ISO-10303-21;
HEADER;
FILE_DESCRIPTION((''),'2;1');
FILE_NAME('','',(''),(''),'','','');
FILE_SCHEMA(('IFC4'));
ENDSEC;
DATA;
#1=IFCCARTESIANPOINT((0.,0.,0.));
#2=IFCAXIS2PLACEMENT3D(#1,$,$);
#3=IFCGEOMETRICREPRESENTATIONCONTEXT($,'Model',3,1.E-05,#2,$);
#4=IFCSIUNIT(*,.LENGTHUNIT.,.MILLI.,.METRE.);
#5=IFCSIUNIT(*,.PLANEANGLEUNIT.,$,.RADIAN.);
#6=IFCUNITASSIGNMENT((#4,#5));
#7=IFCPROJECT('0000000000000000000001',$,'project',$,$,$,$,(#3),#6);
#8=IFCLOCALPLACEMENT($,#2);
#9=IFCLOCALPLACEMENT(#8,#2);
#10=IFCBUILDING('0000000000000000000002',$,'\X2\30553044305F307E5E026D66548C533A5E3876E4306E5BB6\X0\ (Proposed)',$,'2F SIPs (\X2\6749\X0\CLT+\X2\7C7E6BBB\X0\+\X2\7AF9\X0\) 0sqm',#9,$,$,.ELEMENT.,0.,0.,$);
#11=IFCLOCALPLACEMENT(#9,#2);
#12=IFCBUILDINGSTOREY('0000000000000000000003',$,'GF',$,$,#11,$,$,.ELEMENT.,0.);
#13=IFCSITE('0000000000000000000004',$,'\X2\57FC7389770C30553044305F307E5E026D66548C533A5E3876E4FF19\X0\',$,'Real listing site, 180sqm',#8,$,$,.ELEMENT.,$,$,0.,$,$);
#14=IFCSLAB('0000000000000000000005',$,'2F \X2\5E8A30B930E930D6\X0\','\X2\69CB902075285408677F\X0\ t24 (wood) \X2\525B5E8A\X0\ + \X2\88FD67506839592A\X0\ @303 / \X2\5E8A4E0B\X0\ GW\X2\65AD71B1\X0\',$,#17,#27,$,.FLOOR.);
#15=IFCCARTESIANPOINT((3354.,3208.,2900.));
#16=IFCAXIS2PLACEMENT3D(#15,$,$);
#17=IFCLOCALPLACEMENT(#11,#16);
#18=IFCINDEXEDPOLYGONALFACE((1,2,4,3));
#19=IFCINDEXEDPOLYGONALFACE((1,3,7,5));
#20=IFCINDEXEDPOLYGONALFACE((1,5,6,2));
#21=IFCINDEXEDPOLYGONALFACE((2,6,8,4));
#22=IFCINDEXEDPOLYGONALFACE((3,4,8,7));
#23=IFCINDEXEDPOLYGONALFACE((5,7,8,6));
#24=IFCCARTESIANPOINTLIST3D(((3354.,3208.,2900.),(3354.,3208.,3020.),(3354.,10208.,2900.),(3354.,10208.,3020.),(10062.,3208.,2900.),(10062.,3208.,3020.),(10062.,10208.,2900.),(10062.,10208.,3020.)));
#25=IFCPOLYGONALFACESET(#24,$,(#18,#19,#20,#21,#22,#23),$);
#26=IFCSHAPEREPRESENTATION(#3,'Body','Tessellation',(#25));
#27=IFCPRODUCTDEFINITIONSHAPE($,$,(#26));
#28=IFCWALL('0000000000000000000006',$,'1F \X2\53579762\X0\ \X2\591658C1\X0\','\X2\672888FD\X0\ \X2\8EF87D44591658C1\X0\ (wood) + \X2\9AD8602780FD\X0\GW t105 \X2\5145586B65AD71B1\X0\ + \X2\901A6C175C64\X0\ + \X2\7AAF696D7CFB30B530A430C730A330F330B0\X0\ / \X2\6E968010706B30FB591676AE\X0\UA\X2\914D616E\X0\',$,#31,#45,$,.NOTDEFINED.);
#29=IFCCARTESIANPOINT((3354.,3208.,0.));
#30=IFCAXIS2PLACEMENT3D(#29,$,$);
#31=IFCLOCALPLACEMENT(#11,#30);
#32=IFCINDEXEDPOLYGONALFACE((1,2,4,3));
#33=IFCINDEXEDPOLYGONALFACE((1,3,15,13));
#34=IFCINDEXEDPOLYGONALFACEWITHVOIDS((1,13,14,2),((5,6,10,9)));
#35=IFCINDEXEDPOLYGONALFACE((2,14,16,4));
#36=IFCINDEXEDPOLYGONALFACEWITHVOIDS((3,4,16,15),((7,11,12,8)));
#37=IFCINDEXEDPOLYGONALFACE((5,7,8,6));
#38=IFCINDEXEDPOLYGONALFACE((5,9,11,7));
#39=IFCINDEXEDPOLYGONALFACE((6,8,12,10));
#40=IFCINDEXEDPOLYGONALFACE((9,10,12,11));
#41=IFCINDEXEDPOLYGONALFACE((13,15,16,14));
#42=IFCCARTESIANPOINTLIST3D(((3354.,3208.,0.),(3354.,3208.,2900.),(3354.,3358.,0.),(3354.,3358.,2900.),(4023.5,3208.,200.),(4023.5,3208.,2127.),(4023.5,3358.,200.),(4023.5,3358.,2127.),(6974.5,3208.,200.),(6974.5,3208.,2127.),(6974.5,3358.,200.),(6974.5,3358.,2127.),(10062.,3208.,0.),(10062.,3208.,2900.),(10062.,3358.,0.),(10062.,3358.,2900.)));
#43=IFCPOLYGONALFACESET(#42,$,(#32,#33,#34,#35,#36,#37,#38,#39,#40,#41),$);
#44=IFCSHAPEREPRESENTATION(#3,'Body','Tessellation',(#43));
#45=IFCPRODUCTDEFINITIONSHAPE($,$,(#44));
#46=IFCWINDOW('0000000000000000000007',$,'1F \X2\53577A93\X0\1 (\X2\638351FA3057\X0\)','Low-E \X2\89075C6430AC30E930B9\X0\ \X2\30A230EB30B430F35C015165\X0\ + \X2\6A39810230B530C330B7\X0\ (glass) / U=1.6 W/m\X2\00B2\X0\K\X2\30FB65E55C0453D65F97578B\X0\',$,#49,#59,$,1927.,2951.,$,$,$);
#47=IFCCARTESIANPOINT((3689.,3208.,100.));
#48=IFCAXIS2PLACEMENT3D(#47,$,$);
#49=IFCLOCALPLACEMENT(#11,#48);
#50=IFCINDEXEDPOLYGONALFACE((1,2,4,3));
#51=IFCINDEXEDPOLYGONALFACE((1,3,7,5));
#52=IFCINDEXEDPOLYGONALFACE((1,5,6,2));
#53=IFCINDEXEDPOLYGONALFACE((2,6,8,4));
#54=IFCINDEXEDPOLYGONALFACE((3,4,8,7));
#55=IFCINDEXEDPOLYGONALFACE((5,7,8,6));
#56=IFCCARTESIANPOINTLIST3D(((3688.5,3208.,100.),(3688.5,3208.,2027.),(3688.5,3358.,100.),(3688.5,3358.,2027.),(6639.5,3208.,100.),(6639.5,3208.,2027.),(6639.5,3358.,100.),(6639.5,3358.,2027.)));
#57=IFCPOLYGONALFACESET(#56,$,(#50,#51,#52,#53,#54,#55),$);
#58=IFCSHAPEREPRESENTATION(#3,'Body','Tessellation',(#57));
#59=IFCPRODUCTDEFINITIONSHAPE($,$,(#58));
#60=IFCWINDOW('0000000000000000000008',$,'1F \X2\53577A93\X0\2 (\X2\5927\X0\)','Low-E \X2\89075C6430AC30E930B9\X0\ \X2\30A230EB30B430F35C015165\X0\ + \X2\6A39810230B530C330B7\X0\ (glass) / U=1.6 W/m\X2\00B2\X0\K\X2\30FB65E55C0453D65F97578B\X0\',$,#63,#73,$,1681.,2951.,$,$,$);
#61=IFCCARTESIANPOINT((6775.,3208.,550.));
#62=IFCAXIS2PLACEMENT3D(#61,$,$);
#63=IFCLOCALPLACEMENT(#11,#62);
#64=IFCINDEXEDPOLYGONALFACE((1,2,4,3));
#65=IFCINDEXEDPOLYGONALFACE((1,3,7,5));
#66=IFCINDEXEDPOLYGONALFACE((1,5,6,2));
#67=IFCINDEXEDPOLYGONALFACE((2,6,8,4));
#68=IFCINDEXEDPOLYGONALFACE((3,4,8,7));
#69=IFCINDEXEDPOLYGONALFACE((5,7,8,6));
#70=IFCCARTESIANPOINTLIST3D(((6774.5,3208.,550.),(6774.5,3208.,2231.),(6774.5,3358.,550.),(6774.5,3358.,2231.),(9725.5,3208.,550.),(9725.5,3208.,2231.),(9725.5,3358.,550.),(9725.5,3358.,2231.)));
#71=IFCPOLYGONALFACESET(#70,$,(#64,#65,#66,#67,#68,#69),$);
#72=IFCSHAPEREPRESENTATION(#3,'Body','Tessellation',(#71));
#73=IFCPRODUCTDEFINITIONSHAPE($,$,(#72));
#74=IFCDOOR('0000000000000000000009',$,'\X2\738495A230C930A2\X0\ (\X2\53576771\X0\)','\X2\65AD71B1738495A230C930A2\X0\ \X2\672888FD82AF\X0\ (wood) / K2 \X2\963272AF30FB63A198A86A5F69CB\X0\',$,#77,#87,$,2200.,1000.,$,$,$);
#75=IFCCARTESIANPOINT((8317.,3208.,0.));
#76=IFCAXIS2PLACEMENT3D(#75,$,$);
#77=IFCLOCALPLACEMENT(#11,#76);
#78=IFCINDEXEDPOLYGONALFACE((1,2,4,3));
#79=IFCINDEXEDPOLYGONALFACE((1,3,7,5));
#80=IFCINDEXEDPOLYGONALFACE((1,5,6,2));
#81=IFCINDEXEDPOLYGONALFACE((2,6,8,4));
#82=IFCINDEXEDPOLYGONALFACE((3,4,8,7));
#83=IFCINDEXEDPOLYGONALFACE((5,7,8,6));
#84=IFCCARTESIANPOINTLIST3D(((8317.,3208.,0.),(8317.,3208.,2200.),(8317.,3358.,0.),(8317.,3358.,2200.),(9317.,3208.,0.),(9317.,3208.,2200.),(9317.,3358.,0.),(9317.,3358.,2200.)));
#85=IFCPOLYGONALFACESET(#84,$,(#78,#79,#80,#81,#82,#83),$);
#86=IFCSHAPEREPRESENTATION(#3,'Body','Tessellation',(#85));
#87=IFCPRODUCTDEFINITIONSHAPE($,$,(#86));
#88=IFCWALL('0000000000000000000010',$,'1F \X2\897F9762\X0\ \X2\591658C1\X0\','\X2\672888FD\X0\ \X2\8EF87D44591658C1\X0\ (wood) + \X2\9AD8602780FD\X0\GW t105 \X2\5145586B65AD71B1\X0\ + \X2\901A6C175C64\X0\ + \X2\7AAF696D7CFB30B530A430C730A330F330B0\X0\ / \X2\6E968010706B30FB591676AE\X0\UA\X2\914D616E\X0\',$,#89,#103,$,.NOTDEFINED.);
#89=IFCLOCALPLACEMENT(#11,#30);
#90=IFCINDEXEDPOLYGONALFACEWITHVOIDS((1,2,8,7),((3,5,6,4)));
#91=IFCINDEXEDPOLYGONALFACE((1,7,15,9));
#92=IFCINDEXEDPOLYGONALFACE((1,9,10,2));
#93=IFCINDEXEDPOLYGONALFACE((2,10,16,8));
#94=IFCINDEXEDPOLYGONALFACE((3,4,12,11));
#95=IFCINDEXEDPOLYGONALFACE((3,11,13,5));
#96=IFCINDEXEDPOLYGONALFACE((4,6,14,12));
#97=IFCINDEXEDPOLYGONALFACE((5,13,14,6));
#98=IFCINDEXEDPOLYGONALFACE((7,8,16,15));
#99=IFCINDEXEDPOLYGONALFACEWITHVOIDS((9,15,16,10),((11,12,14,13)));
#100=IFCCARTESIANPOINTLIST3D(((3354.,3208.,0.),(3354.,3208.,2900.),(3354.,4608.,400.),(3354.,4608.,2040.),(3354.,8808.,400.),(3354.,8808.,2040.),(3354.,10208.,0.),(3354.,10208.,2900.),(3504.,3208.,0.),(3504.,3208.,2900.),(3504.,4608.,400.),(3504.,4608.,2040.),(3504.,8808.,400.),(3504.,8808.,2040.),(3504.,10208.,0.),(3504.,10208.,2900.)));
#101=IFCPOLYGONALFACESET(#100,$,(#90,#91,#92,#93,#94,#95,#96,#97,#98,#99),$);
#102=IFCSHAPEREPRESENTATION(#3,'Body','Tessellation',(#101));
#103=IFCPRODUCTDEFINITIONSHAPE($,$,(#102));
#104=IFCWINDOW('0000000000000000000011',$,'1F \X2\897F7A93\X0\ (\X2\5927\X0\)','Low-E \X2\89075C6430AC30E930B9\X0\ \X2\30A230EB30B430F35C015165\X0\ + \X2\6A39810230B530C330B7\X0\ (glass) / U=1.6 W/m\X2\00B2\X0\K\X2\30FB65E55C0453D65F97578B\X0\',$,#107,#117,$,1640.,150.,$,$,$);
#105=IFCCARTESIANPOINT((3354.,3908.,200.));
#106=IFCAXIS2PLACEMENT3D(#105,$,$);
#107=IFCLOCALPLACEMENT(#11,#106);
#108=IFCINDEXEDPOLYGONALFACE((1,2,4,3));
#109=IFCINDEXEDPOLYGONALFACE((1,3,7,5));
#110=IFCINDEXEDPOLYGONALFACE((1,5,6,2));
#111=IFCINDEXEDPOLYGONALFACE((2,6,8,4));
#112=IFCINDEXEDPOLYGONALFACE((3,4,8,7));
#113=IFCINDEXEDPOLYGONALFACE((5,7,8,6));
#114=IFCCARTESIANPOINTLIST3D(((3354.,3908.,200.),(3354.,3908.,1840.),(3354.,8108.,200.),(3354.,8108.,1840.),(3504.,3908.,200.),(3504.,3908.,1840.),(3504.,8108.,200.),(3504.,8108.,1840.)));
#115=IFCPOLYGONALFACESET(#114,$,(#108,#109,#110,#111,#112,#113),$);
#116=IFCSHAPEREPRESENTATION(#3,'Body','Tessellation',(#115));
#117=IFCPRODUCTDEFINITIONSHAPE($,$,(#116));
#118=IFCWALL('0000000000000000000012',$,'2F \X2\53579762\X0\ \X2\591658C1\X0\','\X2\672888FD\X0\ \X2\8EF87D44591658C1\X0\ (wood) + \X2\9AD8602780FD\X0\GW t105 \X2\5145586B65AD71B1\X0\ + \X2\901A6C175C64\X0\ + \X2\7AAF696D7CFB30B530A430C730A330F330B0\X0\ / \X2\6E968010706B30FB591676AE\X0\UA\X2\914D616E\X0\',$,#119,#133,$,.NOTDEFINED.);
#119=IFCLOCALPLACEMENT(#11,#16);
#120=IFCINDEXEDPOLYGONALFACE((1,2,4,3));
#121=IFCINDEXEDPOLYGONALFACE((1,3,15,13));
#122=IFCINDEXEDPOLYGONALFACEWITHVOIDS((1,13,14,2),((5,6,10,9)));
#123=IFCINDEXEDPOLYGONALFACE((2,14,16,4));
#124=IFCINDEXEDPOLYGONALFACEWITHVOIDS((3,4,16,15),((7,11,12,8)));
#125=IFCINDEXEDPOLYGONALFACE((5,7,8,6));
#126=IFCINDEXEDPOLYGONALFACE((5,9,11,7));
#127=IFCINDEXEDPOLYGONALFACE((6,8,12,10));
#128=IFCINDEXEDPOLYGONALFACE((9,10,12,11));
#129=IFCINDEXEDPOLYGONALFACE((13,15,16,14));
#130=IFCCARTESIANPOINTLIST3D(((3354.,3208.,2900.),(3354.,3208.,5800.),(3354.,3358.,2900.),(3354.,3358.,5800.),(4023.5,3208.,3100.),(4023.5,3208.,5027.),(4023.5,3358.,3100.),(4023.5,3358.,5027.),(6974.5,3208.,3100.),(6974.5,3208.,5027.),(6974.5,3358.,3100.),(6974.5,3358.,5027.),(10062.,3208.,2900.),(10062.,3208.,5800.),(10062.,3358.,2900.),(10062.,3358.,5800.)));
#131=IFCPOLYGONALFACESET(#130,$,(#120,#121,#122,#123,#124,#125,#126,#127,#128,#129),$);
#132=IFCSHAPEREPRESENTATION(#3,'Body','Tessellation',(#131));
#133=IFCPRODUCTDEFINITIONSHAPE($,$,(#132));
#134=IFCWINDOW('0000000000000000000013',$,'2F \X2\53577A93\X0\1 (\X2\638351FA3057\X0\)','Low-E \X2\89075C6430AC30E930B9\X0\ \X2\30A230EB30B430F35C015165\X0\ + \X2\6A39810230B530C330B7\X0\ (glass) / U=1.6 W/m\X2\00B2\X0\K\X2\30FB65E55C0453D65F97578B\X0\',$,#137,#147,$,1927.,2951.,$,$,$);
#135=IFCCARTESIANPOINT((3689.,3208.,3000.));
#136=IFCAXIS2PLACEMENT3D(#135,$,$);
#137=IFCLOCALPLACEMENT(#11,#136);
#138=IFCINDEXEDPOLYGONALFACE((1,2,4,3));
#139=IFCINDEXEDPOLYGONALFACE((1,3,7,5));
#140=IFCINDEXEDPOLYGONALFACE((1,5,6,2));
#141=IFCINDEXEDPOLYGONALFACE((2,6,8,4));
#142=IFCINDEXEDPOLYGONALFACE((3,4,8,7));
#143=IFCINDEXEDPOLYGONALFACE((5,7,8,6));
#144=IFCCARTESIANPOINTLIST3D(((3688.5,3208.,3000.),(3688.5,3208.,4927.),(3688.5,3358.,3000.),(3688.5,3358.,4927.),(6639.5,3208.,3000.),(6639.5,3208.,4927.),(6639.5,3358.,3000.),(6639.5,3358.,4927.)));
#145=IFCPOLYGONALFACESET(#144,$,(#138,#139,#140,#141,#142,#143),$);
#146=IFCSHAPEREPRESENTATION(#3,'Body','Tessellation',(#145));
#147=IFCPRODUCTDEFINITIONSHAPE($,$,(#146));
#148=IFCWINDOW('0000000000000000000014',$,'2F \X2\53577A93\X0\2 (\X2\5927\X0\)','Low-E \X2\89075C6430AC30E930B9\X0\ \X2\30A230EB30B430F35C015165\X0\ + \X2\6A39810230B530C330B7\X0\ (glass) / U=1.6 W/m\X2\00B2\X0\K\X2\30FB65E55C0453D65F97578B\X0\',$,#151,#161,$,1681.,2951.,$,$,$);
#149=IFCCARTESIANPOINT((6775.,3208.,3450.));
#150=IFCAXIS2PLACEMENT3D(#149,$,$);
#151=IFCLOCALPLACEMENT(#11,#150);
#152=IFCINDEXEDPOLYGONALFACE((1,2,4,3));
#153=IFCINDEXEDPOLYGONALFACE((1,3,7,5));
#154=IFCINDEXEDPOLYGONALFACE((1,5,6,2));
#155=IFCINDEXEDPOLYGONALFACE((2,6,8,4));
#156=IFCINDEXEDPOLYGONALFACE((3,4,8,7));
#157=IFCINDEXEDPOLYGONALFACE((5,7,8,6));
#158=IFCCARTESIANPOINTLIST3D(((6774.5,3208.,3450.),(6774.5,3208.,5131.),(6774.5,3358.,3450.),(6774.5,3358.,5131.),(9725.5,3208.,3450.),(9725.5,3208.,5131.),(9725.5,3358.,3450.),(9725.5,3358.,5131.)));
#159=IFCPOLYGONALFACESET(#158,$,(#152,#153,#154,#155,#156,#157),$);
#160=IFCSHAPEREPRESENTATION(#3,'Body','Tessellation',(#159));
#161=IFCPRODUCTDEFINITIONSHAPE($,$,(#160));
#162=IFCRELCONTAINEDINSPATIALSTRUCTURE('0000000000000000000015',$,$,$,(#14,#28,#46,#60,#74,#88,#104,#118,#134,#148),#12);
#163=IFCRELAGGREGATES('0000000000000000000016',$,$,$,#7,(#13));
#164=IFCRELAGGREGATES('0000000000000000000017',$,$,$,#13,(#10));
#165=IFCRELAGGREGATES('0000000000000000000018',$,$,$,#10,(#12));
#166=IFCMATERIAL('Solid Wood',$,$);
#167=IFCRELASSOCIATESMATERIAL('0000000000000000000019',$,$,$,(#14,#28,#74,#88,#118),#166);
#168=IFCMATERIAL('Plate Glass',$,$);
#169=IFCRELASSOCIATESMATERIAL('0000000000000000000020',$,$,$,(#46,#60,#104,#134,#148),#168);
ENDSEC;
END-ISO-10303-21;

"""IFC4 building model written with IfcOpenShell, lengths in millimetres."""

from ifc_helpers import new_model, si_unit, frame, frame_2d, origin, place, context, project, spatial, rectangle, extrude, material, element, fill, save


model = new_model("IFC4")

# Units and contexts
model_context = context("Model", 3, precision=1e-05, world=origin())
ifc_project = project(units=[si_unit("LENGTHUNIT", "METRE", prefix="MILLI"), si_unit("PLANEANGLEUNIT", "RADIAN")], contexts=[model_context])

# Site, building, storey
site_placement = place(None, origin())
site = spatial("IfcSite", under=ifc_project, at=site_placement, Name="埼玉県さいたま市浦和区常盤９", ObjectType="Real listing site, 180sqm", CompositionType="ELEMENT", RefElevation=0.0)
building_placement = place(site_placement, origin())
building = spatial("IfcBuilding", under=site, at=building_placement, Name="さいたま市浦和区常盤の家 (Proposed)", ObjectType="2F SIPs (杉CLT+籾殻+竹) 0sqm", CompositionType="ELEMENT", ElevationOfRefHeight=0.0, ElevationOfTerrain=0.0)
storey_placement = place(building_placement, origin())
storey = spatial("IfcBuildingStorey", under=building, at=storey_placement, Name="GF", CompositionType="ELEMENT", Elevation=0.0)

# Slab
ifc_material_1 = material(Name="Solid Wood")
slab_1_placement = place(storey_placement, frame((3354.0, 3208.0, 2900.0)))
element("IfcSlab", 1, at=slab_1_placement, inside=storey, material=ifc_material_1, Name="2F 床スラブ", Description="構造用合板 t24 (wood) 剛床 + 製材根太 @303 / 床下 GW断熱", PredefinedType="FLOOR", context=model_context, shape_type="SweptSolid", body=[
    extrude(rectangle(XDim=6708.0, YDim=7000.0, at=frame_2d((3354.0, 3500.0))), frame((3354.0, 3208.0, 2900.0)), (0.0, 0.0, 1.0), 120.0),
])

# Wall, openings, windows, door
wall_1_placement = place(storey_placement, frame((3354.0, 3208.0, 0.0)))
wall_1 = element("IfcWall", 2, at=wall_1_placement, inside=storey, material=ifc_material_1, Name="1F 南面 外壁", Description="木製 軸組外壁 (wood) + 高性能GW t105 充填断熱 + 通気層 + 窯業系サイディング / 準耐火・外皮UA配慮", PredefinedType="NOTDEFINED", context=model_context, shape_type="SweptSolid", body=[
    extrude(rectangle(XDim=6708.0, YDim=150.0, at=frame_2d((3354.0, 75.0))), frame((3354.0, 3208.0, 0.0)), (0.0, 0.0, 1.0), 2900.0),
])
opening_1_placement = place(storey_placement, frame((3689.0, 3208.0, 100.0)))
opening_1 = element("IfcOpeningElement", 3, at=opening_1_placement, cuts=wall_1, PredefinedType="NOTDEFINED", context=model_context, shape_type="SweptSolid", body=[
    extrude(rectangle(XDim=2951.0, YDim=150.0, at=frame_2d((1475.0, 75.0))), frame((3689.0, 3208.0, 100.0)), (0.0, 0.0, 1.0), 1927.0),
])
opening_2_placement = place(storey_placement, frame((6775.0, 3208.0, 550.0)))
opening_2 = element("IfcOpeningElement", 4, at=opening_2_placement, cuts=wall_1, PredefinedType="NOTDEFINED", context=model_context, shape_type="SweptSolid", body=[
    extrude(rectangle(XDim=2951.0, YDim=150.0, at=frame_2d((1475.0, 75.0))), frame((6775.0, 3208.0, 550.0)), (0.0, 0.0, 1.0), 1681.0),
])
opening_3_placement = place(storey_placement, frame((8317.0, 3208.0, 0.0)))
opening_3 = element("IfcOpeningElement", 5, at=opening_3_placement, cuts=wall_1, PredefinedType="NOTDEFINED", context=model_context, shape_type="SweptSolid", body=[
    extrude(rectangle(XDim=1000.0, YDim=150.0, at=frame_2d((500.0, 75.0))), frame((8317.0, 3208.0, 0.0)), (0.0, 0.0, 1.0), 2200.0),
])
ifc_material_2 = material(Name="Plate Glass")
window_1_placement = place(storey_placement, frame((3689.0, 3208.0, 100.0)))
window_1 = element("IfcWindow", 6, at=window_1_placement, inside=storey, material=ifc_material_2, Name="1F 南窓1 (掃出し)", Description="Low-E 複層ガラス アルゴン封入 + 樹脂サッシ (glass) / U=1.6 W/m²K・日射取得型", OverallHeight=1927.0, OverallWidth=2951.0, context=model_context, shape_type="SweptSolid", body=[
    extrude(rectangle(XDim=2951.0, YDim=150.0, at=frame_2d((1475.0, 75.0))), frame((3689.0, 3208.0, 100.0)), (0.0, 0.0, 1.0), 1927.0),
])
fill(opening_1, window_1)
window_2_placement = place(storey_placement, frame((6775.0, 3208.0, 550.0)))
window_2 = element("IfcWindow", 7, at=window_2_placement, inside=storey, material=ifc_material_2, Name="1F 南窓2 (大)", Description="Low-E 複層ガラス アルゴン封入 + 樹脂サッシ (glass) / U=1.6 W/m²K・日射取得型", OverallHeight=1681.0, OverallWidth=2951.0, context=model_context, shape_type="SweptSolid", body=[
    extrude(rectangle(XDim=2951.0, YDim=150.0, at=frame_2d((1475.0, 75.0))), frame((6775.0, 3208.0, 550.0)), (0.0, 0.0, 1.0), 1681.0),
])
fill(opening_2, window_2)
door_placement = place(storey_placement, frame((8317.0, 3208.0, 0.0)))
door = element("IfcDoor", 8, at=door_placement, inside=storey, material=ifc_material_1, Name="玄関ドア (南東)", Description="断熱玄関ドア 木製芯 (wood) / K2 防犯・採風機構", OverallHeight=2200.0, OverallWidth=1000.0, context=model_context, shape_type="SweptSolid", body=[
    extrude(rectangle(XDim=1000.0, YDim=150.0, at=frame_2d((500.0, 75.0))), frame((8317.0, 3208.0, 0.0)), (0.0, 0.0, 1.0), 2200.0),
])
fill(opening_3, door)

# Wall, opening, window
wall_2_placement = place(storey_placement, frame((3354.0, 3208.0, 0.0)))
wall_2 = element("IfcWall", 9, at=wall_2_placement, inside=storey, material=ifc_material_1, Name="1F 西面 外壁", Description="木製 軸組外壁 (wood) + 高性能GW t105 充填断熱 + 通気層 + 窯業系サイディング / 準耐火・外皮UA配慮", PredefinedType="NOTDEFINED", context=model_context, shape_type="SweptSolid", body=[
    extrude(rectangle(XDim=150.0, YDim=7000.0, at=frame_2d((75.0, 3500.0))), frame((3354.0, 3208.0, 0.0)), (0.0, 0.0, 1.0), 2900.0),
])
opening_4_placement = place(storey_placement, frame((3354.0, 3908.0, 200.0)))
opening_4 = element("IfcOpeningElement", 10, at=opening_4_placement, cuts=wall_2, PredefinedType="NOTDEFINED", context=model_context, shape_type="SweptSolid", body=[
    extrude(rectangle(XDim=150.0, YDim=4200.0, at=frame_2d((75.0, 2100.0))), frame((3354.0, 3908.0, 200.0)), (0.0, 0.0, 1.0), 1640.0),
])
window_3_placement = place(storey_placement, frame((3354.0, 3908.0, 200.0)))
window_3 = element("IfcWindow", 11, at=window_3_placement, inside=storey, material=ifc_material_2, Name="1F 西窓 (大)", Description="Low-E 複層ガラス アルゴン封入 + 樹脂サッシ (glass) / U=1.6 W/m²K・日射取得型", OverallHeight=1640.0, OverallWidth=150.0, context=model_context, shape_type="SweptSolid", body=[
    extrude(rectangle(XDim=150.0, YDim=4200.0, at=frame_2d((75.0, 2100.0))), frame((3354.0, 3908.0, 200.0)), (0.0, 0.0, 1.0), 1640.0),
])
fill(opening_4, window_3)

# Wall, openings, windows
wall_3_placement = place(storey_placement, frame((3354.0, 3208.0, 2900.0)))
wall_3 = element("IfcWall", 12, at=wall_3_placement, inside=storey, material=ifc_material_1, Name="2F 南面 外壁", Description="木製 軸組外壁 (wood) + 高性能GW t105 充填断熱 + 通気層 + 窯業系サイディング / 準耐火・外皮UA配慮", PredefinedType="NOTDEFINED", context=model_context, shape_type="SweptSolid", body=[
    extrude(rectangle(XDim=6708.0, YDim=150.0, at=frame_2d((3354.0, 75.0))), frame((3354.0, 3208.0, 2900.0)), (0.0, 0.0, 1.0), 2900.0),
])
opening_5_placement = place(storey_placement, frame((3689.0, 3208.0, 3000.0)))
opening_5 = element("IfcOpeningElement", 13, at=opening_5_placement, cuts=wall_3, PredefinedType="NOTDEFINED", context=model_context, shape_type="SweptSolid", body=[
    extrude(rectangle(XDim=2951.0, YDim=150.0, at=frame_2d((1475.0, 75.0))), frame((3689.0, 3208.0, 3000.0)), (0.0, 0.0, 1.0), 1927.0),
])
opening_6_placement = place(storey_placement, frame((6775.0, 3208.0, 3450.0)))
opening_6 = element("IfcOpeningElement", 14, at=opening_6_placement, cuts=wall_3, PredefinedType="NOTDEFINED", context=model_context, shape_type="SweptSolid", body=[
    extrude(rectangle(XDim=2951.0, YDim=150.0, at=frame_2d((1475.0, 75.0))), frame((6775.0, 3208.0, 3450.0)), (0.0, 0.0, 1.0), 1681.0),
])
window_4_placement = place(storey_placement, frame((3689.0, 3208.0, 3000.0)))
window_4 = element("IfcWindow", 15, at=window_4_placement, inside=storey, material=ifc_material_2, Name="2F 南窓1 (掃出し)", Description="Low-E 複層ガラス アルゴン封入 + 樹脂サッシ (glass) / U=1.6 W/m²K・日射取得型", OverallHeight=1927.0, OverallWidth=2951.0, context=model_context, shape_type="SweptSolid", body=[
    extrude(rectangle(XDim=2951.0, YDim=150.0, at=frame_2d((1475.0, 75.0))), frame((3689.0, 3208.0, 3000.0)), (0.0, 0.0, 1.0), 1927.0),
])
fill(opening_5, window_4)
window_5_placement = place(storey_placement, frame((6775.0, 3208.0, 3450.0)))
window_5 = element("IfcWindow", 16, at=window_5_placement, inside=storey, material=ifc_material_2, Name="2F 南窓2 (大)", Description="Low-E 複層ガラス アルゴン封入 + 樹脂サッシ (glass) / U=1.6 W/m²K・日射取得型", OverallHeight=1681.0, OverallWidth=2951.0, context=model_context, shape_type="SweptSolid", body=[
    extrude(rectangle(XDim=2951.0, YDim=150.0, at=frame_2d((1475.0, 75.0))), frame((6775.0, 3208.0, 3450.0)), (0.0, 0.0, 1.0), 1681.0),
])
fill(opening_6, window_5)

save(model, "model.ifc")
